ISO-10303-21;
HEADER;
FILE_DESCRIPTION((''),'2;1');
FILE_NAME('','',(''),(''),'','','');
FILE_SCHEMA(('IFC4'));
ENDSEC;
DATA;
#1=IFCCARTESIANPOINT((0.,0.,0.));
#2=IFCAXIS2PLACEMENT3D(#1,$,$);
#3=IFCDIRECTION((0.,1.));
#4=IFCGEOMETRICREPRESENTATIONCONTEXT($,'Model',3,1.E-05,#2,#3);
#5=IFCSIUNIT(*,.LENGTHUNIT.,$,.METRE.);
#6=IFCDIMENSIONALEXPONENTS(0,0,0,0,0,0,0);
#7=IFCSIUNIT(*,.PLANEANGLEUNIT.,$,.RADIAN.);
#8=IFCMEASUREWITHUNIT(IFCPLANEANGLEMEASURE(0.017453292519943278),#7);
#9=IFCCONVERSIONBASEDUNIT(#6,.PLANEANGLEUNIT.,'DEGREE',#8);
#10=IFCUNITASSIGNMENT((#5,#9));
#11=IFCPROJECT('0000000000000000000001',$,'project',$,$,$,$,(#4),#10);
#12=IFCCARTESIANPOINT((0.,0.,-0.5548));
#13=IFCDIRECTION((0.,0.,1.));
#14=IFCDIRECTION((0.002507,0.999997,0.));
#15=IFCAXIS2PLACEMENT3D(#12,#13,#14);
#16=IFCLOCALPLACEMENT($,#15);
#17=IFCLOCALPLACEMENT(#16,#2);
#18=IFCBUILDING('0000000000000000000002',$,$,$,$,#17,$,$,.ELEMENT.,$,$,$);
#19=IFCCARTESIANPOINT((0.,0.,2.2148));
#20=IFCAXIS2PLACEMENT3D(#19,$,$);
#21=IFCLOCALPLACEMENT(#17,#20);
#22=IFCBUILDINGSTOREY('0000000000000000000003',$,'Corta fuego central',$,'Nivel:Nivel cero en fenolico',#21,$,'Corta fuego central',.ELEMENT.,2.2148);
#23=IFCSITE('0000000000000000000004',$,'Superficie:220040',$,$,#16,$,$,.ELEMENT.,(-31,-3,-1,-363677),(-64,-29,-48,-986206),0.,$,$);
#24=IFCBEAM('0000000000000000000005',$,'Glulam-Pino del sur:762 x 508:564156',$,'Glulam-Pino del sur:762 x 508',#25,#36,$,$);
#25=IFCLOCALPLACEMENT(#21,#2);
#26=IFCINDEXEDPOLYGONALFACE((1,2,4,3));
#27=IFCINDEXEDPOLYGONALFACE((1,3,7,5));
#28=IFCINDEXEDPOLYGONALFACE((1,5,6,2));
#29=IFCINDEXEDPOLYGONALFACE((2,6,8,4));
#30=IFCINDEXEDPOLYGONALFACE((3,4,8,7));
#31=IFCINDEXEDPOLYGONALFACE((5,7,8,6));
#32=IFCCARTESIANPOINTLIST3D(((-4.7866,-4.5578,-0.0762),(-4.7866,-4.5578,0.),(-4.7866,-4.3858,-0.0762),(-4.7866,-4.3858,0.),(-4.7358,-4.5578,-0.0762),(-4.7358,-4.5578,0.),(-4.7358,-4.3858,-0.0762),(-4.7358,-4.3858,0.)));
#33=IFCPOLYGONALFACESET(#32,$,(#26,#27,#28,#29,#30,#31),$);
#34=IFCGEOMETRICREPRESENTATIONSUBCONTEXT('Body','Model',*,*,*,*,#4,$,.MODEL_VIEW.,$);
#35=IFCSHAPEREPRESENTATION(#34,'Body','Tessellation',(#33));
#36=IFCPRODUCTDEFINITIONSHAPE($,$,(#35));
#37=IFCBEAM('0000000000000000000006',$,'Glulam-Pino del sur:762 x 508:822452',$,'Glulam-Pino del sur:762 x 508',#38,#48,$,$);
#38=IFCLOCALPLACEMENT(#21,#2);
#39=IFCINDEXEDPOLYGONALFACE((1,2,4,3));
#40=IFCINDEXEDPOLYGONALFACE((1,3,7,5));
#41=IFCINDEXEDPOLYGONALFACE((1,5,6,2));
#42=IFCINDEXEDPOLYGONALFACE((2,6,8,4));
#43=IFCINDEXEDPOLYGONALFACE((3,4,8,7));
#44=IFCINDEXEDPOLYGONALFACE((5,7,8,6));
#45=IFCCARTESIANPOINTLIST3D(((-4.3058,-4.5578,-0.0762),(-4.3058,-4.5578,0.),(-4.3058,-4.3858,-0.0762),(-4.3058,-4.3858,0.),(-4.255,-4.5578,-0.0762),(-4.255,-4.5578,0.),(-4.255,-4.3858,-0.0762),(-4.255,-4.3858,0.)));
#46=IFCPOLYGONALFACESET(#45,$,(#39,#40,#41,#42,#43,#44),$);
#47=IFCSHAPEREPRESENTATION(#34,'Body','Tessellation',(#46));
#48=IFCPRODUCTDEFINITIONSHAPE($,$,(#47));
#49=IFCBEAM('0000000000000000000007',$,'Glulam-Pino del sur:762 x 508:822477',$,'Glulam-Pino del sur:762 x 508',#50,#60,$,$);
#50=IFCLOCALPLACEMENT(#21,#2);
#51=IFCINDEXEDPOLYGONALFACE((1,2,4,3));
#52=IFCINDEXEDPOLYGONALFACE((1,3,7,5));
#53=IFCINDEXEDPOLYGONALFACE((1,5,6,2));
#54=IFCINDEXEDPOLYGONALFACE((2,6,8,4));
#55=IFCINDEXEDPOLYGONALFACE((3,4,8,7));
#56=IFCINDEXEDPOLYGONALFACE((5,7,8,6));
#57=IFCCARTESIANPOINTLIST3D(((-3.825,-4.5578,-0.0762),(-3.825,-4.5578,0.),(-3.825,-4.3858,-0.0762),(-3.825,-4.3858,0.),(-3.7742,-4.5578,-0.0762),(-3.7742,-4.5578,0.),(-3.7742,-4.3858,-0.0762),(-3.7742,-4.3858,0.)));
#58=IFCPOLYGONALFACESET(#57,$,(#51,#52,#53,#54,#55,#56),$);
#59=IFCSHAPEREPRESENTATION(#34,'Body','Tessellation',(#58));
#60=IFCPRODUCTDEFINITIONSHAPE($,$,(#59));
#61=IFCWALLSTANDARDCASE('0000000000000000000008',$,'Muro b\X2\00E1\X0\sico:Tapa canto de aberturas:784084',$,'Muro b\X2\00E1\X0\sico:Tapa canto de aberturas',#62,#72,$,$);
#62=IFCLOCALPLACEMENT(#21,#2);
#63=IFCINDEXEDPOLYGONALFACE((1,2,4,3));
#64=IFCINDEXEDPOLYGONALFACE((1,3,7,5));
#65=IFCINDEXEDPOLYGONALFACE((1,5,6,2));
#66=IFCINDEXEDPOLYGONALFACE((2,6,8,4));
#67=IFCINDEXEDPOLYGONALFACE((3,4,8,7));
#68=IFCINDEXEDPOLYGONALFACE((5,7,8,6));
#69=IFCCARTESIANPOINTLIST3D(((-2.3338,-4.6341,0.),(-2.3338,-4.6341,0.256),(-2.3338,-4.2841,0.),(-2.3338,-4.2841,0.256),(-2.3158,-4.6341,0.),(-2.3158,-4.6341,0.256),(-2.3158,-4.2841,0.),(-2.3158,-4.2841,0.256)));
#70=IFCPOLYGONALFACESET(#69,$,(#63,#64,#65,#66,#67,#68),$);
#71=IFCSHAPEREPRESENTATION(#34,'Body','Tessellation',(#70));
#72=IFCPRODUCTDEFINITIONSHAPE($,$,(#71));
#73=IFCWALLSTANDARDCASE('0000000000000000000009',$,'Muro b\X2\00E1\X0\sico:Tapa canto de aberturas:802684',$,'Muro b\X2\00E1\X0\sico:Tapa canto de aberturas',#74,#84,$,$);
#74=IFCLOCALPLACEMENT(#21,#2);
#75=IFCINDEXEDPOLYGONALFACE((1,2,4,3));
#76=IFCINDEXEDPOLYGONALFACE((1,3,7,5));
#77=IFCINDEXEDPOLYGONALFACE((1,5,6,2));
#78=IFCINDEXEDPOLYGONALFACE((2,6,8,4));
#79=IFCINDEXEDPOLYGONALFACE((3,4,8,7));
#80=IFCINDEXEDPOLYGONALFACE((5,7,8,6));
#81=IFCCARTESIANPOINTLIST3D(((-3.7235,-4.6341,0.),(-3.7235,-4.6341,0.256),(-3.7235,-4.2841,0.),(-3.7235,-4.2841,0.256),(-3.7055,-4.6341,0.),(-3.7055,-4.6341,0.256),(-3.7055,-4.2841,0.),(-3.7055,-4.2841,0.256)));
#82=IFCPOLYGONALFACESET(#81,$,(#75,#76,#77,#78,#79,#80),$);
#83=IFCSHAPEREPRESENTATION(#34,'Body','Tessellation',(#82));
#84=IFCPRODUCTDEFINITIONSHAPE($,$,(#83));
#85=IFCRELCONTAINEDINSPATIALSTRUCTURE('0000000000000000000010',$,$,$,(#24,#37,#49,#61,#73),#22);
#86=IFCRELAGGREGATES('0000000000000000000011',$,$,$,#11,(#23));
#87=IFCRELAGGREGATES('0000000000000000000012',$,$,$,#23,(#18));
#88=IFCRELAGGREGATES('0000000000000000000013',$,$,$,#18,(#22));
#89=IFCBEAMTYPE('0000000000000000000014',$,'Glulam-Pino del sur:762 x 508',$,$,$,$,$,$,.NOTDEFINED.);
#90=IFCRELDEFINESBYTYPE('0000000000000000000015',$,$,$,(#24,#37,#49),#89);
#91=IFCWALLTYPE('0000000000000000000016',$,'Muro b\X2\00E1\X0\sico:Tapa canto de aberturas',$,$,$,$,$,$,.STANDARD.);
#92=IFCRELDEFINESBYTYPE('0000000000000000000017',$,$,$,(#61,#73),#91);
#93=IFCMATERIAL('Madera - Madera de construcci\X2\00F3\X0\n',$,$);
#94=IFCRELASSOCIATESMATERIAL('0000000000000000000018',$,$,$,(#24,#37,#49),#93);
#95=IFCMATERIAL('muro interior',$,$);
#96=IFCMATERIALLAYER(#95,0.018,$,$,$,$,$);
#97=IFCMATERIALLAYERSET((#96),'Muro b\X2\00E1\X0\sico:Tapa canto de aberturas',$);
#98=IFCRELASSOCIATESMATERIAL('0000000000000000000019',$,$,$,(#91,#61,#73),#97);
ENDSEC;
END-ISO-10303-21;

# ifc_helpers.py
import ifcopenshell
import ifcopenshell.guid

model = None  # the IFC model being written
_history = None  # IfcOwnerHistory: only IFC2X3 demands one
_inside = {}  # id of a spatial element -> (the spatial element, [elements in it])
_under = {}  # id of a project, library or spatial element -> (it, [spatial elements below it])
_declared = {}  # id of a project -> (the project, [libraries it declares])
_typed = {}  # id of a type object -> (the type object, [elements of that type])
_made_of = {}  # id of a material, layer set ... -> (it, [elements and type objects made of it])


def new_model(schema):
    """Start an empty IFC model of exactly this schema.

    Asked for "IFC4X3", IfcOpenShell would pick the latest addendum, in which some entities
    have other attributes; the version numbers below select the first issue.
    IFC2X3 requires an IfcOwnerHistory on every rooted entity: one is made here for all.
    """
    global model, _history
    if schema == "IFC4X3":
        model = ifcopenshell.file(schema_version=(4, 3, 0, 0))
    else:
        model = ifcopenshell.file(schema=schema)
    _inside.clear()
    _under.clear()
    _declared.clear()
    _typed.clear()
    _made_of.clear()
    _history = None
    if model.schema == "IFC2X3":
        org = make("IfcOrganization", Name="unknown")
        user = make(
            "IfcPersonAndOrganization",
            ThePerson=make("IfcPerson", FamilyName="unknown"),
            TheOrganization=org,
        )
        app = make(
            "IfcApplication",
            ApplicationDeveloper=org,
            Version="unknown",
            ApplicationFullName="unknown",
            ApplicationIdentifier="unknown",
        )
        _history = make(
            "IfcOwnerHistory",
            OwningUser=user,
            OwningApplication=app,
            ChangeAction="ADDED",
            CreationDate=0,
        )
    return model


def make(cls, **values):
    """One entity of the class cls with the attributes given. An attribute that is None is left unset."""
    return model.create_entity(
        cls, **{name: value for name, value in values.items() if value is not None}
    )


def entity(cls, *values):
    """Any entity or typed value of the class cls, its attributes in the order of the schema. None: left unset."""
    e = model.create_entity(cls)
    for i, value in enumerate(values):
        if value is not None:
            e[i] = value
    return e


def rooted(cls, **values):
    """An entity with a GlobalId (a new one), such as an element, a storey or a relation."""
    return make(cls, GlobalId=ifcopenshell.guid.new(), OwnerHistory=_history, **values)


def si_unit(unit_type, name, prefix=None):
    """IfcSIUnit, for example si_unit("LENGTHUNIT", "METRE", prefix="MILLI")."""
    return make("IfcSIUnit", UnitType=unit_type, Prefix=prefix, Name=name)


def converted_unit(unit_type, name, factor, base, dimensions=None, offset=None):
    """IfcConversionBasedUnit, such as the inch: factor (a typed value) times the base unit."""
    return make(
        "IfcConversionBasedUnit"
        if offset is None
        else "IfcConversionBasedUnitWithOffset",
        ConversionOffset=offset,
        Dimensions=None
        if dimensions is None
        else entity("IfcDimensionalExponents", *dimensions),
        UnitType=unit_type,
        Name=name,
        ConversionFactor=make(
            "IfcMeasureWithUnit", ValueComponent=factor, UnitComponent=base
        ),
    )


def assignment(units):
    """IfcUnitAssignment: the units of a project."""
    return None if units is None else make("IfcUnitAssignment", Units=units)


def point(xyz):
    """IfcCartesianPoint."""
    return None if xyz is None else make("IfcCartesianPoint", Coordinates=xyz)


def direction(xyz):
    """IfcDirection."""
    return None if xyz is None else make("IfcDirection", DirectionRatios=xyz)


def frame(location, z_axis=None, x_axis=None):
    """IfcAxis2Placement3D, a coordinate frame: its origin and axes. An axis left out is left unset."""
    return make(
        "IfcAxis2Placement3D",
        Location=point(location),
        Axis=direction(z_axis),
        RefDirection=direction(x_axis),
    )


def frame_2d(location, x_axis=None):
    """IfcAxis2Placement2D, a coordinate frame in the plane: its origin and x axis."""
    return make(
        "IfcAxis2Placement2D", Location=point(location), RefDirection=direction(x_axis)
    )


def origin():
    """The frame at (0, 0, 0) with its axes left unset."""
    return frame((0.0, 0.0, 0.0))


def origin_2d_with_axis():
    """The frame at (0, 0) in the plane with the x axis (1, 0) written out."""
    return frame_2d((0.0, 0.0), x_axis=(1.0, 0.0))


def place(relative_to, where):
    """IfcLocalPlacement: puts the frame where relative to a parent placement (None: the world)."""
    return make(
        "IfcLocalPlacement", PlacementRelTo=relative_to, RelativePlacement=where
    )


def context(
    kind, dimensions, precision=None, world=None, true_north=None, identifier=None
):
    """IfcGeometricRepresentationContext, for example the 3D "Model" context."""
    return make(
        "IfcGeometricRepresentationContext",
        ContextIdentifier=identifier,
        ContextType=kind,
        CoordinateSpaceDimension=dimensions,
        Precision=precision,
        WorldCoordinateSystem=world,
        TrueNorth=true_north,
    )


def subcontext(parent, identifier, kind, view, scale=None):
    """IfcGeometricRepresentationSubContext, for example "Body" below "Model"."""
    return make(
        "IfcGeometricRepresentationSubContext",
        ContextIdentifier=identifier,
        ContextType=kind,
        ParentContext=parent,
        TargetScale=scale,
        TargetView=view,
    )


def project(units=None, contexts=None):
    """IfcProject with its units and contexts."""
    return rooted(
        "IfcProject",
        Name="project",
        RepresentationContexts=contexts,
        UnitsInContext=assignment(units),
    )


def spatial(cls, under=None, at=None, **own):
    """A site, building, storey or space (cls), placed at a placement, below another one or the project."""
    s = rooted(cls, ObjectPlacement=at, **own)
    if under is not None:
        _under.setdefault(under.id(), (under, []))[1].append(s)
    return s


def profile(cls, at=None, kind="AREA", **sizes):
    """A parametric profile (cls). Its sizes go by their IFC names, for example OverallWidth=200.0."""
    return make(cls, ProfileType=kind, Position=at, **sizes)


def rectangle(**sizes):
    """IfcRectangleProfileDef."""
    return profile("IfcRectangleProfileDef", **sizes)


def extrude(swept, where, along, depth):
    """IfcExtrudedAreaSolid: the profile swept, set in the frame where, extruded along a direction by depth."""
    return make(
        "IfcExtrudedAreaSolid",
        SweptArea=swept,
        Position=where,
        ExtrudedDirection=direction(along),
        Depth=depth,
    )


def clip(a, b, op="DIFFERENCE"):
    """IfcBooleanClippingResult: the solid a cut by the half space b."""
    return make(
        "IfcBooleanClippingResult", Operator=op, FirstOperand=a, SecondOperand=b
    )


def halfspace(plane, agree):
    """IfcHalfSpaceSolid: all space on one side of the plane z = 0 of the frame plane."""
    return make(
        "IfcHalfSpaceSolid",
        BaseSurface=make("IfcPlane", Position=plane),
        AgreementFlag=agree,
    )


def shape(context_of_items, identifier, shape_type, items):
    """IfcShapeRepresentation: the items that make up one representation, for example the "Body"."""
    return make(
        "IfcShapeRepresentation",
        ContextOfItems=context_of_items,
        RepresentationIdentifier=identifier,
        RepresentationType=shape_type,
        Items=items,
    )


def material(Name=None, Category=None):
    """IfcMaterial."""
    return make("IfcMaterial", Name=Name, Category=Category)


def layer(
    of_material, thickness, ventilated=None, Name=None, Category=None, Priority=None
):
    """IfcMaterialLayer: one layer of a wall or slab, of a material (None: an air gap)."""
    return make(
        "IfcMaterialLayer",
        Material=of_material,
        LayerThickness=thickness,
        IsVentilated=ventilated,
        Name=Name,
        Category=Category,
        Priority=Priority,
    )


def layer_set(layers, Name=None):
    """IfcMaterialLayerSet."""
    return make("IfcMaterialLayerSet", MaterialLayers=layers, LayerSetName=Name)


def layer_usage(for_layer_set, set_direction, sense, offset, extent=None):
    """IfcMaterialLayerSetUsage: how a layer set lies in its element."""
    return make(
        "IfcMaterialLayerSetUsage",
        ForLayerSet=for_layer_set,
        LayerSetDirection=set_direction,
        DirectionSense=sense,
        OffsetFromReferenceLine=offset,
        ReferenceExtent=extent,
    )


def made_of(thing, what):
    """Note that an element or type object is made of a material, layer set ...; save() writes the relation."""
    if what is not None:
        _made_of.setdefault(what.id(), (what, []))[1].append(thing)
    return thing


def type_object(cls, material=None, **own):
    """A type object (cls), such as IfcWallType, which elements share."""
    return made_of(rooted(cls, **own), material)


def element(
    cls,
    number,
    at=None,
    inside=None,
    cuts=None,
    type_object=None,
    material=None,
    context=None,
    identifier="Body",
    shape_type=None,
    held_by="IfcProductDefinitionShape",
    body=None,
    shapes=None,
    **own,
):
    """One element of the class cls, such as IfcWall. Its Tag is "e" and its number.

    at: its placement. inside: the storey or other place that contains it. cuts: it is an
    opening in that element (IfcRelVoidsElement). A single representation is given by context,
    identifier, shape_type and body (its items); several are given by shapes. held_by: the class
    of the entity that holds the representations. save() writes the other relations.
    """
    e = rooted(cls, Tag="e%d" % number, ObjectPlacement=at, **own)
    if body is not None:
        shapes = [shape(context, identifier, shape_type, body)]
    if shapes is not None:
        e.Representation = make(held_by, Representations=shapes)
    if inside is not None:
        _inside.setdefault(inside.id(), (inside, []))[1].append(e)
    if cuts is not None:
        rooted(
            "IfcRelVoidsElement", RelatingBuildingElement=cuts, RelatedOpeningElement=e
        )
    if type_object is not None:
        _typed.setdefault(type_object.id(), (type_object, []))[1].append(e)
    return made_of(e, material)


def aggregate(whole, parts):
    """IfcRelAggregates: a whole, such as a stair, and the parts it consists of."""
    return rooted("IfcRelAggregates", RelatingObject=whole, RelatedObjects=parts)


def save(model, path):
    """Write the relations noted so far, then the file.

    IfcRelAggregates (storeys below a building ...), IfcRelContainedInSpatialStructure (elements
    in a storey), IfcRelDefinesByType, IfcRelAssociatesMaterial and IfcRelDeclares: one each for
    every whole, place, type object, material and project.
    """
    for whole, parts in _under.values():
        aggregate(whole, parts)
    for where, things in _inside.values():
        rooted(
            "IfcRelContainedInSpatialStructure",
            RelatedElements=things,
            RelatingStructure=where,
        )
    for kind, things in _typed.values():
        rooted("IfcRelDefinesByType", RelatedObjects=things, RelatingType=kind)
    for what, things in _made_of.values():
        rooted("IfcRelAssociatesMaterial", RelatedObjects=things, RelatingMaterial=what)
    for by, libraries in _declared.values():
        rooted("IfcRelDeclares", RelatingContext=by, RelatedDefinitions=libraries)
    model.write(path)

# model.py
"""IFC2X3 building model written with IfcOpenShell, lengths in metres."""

from ifc_helpers import new_model, entity, si_unit, converted_unit, direction, frame, frame_2d, origin, origin_2d_with_axis, place, context, subcontext, project, spatial, rectangle, extrude, clip, halfspace, material, layer, layer_set, layer_usage, type_object, element, save


model = new_model("IFC2X3")

# Units and contexts
model_context = context("Model", 3, precision=1e-05, world=origin(), true_north=direction((0.0, 1.0)))
body_context = subcontext(model_context, "Body", "Model", "MODEL_VIEW")
ifc_project = project(units=[si_unit("LENGTHUNIT", "METRE"), converted_unit("PLANEANGLEUNIT", "DEGREE", entity("IfcPlaneAngleMeasure", 0.017453292519943278), si_unit("PLANEANGLEUNIT", "RADIAN"), dimensions=[0, 0, 0, 0, 0, 0, 0])], contexts=[model_context])

# Site, building, storey
site_placement = place(None, frame((0.0, 0.0, -0.5548), z_axis=(0.0, 0.0, 1.0), x_axis=(0.002507, 0.999997, 0.0)))
site = spatial("IfcSite", under=ifc_project, at=site_placement, Name="Superficie:220040", CompositionType="ELEMENT", RefLatitude=(-31, -3, -1, -363677), RefLongitude=(-64, -29, -48, -986206), RefElevation=0.0)
building_placement = place(site_placement, origin())
building = spatial("IfcBuilding", under=site, at=building_placement, CompositionType="ELEMENT")
storey_placement = place(building_placement, frame((0.0, 0.0, 2.2148)))
storey = spatial("IfcBuildingStorey", under=building, at=storey_placement, Name="Corta fuego central", ObjectType="Nivel:Nivel cero en fenolico", LongName="Corta fuego central", CompositionType="ELEMENT", Elevation=2.2148)

# Shared definitions
ifc_material_1 = material(Name="Madera - Madera de construcción")

# Beams
beam_type_1 = type_object("IfcBeamType", Name="Glulam-Pino del sur:762 x 508", PredefinedType="NOTDEFINED")
beam_1_placement = place(storey_placement, frame((-4.7612, -4.5579, 0.0), z_axis=(0.0, 0.0, 1.0), x_axis=(0.0, 1.0, 0.0)))
element("IfcBeam", 1, at=beam_1_placement, inside=storey, type_object=beam_type_1, material=ifc_material_1, Name="Glulam-Pino del sur:762 x 508:564156", ObjectType="Glulam-Pino del sur:762 x 508", context=body_context, shape_type="SweptSolid", body=[
    extrude(rectangle(XDim=0.0762, YDim=0.0508, at=origin_2d_with_axis()), frame((0.0001, 0.0, -0.0381), z_axis=(1.0, 0.0, 0.0), x_axis=(0.0, 0.0, -1.0)), (0.0, 0.0, 1.0), 0.172),
])
beam_2_placement = place(storey_placement, frame((-4.2804, -4.5579, 0.0), z_axis=(0.0, 0.0, 1.0), x_axis=(0.0, 1.0, 0.0)))
element("IfcBeam", 2, at=beam_2_placement, inside=storey, type_object=beam_type_1, material=ifc_material_1, Name="Glulam-Pino del sur:762 x 508:822452", ObjectType="Glulam-Pino del sur:762 x 508", context=body_context, shape_type="SweptSolid", body=[
    extrude(rectangle(XDim=0.0762, YDim=0.0508, at=origin_2d_with_axis()), frame((0.0001, 0.0, -0.0381), z_axis=(1.0, 0.0, 0.0), x_axis=(0.0, 0.0, -1.0)), (0.0, 0.0, 1.0), 0.172),
])
beam_3_placement = place(storey_placement, frame((-3.7996, -4.5579, 0.0), z_axis=(0.0, 0.0, 1.0), x_axis=(0.0, 1.0, 0.0)))
element("IfcBeam", 3, at=beam_3_placement, inside=storey, type_object=beam_type_1, material=ifc_material_1, Name="Glulam-Pino del sur:762 x 508:822477", ObjectType="Glulam-Pino del sur:762 x 508", context=body_context, shape_type="SweptSolid", body=[
    extrude(rectangle(XDim=0.0762, YDim=0.0508, at=origin_2d_with_axis()), frame((0.0001, 0.0, -0.0381), z_axis=(1.0, 0.0, 0.0), x_axis=(0.0, 0.0, -1.0)), (0.0, 0.0, 1.0), 0.172),
])

# Walls
ifc_material_2 = material(Name="muro interior")
ifc_layer = layer(ifc_material_2, 0.018)
ifc_layer_set = layer_set([ifc_layer], Name="Muro básico:Tapa canto de aberturas")
ifc_layer_usage_1 = layer_usage(ifc_layer_set, "AXIS2", "POSITIVE", -0.009)
wall_type = type_object("IfcWallType", Name="Muro básico:Tapa canto de aberturas", PredefinedType="STANDARD", material=ifc_layer_set)
wall_1_placement = place(storey_placement, frame((-2.3248, -4.6341, 0.0), z_axis=(0.0, 0.0, 1.0), x_axis=(0.0, 1.0, 0.0)))
element("IfcWallStandardCase", 4, at=wall_1_placement, inside=storey, type_object=wall_type, material=ifc_layer_usage_1, Name="Muro básico:Tapa canto de aberturas:784084", ObjectType="Muro básico:Tapa canto de aberturas", context=body_context, shape_type="Clipping", body=[
    clip(extrude(rectangle(XDim=0.35, YDim=0.018, at=frame_2d((0.175, 0.0), x_axis=(-1.0, 0.0))), origin(), (0.0, 0.0, 1.0), 0.256), halfspace(frame((0.0, 0.0, -1.3348)), True)),
])
ifc_layer_usage_2 = layer_usage(ifc_layer_set, "AXIS2", "NEGATIVE", 0.009)
wall_2_placement = place(storey_placement, frame((-3.7145, -4.6341, 0.0), z_axis=(0.0, 0.0, 1.0), x_axis=(0.0, 1.0, 0.0)))
element("IfcWallStandardCase", 5, at=wall_2_placement, inside=storey, type_object=wall_type, material=ifc_layer_usage_2, Name="Muro básico:Tapa canto de aberturas:802684", ObjectType="Muro básico:Tapa canto de aberturas", context=body_context, shape_type="Clipping", body=[
    clip(extrude(rectangle(XDim=0.35, YDim=0.018, at=frame_2d((0.175, 0.0), x_axis=(-1.0, 0.0))), origin(), (0.0, 0.0, 1.0), 0.256), halfspace(frame((0.0, 0.0, -1.3348)), True)),
])

save(model, "model.ifc")
